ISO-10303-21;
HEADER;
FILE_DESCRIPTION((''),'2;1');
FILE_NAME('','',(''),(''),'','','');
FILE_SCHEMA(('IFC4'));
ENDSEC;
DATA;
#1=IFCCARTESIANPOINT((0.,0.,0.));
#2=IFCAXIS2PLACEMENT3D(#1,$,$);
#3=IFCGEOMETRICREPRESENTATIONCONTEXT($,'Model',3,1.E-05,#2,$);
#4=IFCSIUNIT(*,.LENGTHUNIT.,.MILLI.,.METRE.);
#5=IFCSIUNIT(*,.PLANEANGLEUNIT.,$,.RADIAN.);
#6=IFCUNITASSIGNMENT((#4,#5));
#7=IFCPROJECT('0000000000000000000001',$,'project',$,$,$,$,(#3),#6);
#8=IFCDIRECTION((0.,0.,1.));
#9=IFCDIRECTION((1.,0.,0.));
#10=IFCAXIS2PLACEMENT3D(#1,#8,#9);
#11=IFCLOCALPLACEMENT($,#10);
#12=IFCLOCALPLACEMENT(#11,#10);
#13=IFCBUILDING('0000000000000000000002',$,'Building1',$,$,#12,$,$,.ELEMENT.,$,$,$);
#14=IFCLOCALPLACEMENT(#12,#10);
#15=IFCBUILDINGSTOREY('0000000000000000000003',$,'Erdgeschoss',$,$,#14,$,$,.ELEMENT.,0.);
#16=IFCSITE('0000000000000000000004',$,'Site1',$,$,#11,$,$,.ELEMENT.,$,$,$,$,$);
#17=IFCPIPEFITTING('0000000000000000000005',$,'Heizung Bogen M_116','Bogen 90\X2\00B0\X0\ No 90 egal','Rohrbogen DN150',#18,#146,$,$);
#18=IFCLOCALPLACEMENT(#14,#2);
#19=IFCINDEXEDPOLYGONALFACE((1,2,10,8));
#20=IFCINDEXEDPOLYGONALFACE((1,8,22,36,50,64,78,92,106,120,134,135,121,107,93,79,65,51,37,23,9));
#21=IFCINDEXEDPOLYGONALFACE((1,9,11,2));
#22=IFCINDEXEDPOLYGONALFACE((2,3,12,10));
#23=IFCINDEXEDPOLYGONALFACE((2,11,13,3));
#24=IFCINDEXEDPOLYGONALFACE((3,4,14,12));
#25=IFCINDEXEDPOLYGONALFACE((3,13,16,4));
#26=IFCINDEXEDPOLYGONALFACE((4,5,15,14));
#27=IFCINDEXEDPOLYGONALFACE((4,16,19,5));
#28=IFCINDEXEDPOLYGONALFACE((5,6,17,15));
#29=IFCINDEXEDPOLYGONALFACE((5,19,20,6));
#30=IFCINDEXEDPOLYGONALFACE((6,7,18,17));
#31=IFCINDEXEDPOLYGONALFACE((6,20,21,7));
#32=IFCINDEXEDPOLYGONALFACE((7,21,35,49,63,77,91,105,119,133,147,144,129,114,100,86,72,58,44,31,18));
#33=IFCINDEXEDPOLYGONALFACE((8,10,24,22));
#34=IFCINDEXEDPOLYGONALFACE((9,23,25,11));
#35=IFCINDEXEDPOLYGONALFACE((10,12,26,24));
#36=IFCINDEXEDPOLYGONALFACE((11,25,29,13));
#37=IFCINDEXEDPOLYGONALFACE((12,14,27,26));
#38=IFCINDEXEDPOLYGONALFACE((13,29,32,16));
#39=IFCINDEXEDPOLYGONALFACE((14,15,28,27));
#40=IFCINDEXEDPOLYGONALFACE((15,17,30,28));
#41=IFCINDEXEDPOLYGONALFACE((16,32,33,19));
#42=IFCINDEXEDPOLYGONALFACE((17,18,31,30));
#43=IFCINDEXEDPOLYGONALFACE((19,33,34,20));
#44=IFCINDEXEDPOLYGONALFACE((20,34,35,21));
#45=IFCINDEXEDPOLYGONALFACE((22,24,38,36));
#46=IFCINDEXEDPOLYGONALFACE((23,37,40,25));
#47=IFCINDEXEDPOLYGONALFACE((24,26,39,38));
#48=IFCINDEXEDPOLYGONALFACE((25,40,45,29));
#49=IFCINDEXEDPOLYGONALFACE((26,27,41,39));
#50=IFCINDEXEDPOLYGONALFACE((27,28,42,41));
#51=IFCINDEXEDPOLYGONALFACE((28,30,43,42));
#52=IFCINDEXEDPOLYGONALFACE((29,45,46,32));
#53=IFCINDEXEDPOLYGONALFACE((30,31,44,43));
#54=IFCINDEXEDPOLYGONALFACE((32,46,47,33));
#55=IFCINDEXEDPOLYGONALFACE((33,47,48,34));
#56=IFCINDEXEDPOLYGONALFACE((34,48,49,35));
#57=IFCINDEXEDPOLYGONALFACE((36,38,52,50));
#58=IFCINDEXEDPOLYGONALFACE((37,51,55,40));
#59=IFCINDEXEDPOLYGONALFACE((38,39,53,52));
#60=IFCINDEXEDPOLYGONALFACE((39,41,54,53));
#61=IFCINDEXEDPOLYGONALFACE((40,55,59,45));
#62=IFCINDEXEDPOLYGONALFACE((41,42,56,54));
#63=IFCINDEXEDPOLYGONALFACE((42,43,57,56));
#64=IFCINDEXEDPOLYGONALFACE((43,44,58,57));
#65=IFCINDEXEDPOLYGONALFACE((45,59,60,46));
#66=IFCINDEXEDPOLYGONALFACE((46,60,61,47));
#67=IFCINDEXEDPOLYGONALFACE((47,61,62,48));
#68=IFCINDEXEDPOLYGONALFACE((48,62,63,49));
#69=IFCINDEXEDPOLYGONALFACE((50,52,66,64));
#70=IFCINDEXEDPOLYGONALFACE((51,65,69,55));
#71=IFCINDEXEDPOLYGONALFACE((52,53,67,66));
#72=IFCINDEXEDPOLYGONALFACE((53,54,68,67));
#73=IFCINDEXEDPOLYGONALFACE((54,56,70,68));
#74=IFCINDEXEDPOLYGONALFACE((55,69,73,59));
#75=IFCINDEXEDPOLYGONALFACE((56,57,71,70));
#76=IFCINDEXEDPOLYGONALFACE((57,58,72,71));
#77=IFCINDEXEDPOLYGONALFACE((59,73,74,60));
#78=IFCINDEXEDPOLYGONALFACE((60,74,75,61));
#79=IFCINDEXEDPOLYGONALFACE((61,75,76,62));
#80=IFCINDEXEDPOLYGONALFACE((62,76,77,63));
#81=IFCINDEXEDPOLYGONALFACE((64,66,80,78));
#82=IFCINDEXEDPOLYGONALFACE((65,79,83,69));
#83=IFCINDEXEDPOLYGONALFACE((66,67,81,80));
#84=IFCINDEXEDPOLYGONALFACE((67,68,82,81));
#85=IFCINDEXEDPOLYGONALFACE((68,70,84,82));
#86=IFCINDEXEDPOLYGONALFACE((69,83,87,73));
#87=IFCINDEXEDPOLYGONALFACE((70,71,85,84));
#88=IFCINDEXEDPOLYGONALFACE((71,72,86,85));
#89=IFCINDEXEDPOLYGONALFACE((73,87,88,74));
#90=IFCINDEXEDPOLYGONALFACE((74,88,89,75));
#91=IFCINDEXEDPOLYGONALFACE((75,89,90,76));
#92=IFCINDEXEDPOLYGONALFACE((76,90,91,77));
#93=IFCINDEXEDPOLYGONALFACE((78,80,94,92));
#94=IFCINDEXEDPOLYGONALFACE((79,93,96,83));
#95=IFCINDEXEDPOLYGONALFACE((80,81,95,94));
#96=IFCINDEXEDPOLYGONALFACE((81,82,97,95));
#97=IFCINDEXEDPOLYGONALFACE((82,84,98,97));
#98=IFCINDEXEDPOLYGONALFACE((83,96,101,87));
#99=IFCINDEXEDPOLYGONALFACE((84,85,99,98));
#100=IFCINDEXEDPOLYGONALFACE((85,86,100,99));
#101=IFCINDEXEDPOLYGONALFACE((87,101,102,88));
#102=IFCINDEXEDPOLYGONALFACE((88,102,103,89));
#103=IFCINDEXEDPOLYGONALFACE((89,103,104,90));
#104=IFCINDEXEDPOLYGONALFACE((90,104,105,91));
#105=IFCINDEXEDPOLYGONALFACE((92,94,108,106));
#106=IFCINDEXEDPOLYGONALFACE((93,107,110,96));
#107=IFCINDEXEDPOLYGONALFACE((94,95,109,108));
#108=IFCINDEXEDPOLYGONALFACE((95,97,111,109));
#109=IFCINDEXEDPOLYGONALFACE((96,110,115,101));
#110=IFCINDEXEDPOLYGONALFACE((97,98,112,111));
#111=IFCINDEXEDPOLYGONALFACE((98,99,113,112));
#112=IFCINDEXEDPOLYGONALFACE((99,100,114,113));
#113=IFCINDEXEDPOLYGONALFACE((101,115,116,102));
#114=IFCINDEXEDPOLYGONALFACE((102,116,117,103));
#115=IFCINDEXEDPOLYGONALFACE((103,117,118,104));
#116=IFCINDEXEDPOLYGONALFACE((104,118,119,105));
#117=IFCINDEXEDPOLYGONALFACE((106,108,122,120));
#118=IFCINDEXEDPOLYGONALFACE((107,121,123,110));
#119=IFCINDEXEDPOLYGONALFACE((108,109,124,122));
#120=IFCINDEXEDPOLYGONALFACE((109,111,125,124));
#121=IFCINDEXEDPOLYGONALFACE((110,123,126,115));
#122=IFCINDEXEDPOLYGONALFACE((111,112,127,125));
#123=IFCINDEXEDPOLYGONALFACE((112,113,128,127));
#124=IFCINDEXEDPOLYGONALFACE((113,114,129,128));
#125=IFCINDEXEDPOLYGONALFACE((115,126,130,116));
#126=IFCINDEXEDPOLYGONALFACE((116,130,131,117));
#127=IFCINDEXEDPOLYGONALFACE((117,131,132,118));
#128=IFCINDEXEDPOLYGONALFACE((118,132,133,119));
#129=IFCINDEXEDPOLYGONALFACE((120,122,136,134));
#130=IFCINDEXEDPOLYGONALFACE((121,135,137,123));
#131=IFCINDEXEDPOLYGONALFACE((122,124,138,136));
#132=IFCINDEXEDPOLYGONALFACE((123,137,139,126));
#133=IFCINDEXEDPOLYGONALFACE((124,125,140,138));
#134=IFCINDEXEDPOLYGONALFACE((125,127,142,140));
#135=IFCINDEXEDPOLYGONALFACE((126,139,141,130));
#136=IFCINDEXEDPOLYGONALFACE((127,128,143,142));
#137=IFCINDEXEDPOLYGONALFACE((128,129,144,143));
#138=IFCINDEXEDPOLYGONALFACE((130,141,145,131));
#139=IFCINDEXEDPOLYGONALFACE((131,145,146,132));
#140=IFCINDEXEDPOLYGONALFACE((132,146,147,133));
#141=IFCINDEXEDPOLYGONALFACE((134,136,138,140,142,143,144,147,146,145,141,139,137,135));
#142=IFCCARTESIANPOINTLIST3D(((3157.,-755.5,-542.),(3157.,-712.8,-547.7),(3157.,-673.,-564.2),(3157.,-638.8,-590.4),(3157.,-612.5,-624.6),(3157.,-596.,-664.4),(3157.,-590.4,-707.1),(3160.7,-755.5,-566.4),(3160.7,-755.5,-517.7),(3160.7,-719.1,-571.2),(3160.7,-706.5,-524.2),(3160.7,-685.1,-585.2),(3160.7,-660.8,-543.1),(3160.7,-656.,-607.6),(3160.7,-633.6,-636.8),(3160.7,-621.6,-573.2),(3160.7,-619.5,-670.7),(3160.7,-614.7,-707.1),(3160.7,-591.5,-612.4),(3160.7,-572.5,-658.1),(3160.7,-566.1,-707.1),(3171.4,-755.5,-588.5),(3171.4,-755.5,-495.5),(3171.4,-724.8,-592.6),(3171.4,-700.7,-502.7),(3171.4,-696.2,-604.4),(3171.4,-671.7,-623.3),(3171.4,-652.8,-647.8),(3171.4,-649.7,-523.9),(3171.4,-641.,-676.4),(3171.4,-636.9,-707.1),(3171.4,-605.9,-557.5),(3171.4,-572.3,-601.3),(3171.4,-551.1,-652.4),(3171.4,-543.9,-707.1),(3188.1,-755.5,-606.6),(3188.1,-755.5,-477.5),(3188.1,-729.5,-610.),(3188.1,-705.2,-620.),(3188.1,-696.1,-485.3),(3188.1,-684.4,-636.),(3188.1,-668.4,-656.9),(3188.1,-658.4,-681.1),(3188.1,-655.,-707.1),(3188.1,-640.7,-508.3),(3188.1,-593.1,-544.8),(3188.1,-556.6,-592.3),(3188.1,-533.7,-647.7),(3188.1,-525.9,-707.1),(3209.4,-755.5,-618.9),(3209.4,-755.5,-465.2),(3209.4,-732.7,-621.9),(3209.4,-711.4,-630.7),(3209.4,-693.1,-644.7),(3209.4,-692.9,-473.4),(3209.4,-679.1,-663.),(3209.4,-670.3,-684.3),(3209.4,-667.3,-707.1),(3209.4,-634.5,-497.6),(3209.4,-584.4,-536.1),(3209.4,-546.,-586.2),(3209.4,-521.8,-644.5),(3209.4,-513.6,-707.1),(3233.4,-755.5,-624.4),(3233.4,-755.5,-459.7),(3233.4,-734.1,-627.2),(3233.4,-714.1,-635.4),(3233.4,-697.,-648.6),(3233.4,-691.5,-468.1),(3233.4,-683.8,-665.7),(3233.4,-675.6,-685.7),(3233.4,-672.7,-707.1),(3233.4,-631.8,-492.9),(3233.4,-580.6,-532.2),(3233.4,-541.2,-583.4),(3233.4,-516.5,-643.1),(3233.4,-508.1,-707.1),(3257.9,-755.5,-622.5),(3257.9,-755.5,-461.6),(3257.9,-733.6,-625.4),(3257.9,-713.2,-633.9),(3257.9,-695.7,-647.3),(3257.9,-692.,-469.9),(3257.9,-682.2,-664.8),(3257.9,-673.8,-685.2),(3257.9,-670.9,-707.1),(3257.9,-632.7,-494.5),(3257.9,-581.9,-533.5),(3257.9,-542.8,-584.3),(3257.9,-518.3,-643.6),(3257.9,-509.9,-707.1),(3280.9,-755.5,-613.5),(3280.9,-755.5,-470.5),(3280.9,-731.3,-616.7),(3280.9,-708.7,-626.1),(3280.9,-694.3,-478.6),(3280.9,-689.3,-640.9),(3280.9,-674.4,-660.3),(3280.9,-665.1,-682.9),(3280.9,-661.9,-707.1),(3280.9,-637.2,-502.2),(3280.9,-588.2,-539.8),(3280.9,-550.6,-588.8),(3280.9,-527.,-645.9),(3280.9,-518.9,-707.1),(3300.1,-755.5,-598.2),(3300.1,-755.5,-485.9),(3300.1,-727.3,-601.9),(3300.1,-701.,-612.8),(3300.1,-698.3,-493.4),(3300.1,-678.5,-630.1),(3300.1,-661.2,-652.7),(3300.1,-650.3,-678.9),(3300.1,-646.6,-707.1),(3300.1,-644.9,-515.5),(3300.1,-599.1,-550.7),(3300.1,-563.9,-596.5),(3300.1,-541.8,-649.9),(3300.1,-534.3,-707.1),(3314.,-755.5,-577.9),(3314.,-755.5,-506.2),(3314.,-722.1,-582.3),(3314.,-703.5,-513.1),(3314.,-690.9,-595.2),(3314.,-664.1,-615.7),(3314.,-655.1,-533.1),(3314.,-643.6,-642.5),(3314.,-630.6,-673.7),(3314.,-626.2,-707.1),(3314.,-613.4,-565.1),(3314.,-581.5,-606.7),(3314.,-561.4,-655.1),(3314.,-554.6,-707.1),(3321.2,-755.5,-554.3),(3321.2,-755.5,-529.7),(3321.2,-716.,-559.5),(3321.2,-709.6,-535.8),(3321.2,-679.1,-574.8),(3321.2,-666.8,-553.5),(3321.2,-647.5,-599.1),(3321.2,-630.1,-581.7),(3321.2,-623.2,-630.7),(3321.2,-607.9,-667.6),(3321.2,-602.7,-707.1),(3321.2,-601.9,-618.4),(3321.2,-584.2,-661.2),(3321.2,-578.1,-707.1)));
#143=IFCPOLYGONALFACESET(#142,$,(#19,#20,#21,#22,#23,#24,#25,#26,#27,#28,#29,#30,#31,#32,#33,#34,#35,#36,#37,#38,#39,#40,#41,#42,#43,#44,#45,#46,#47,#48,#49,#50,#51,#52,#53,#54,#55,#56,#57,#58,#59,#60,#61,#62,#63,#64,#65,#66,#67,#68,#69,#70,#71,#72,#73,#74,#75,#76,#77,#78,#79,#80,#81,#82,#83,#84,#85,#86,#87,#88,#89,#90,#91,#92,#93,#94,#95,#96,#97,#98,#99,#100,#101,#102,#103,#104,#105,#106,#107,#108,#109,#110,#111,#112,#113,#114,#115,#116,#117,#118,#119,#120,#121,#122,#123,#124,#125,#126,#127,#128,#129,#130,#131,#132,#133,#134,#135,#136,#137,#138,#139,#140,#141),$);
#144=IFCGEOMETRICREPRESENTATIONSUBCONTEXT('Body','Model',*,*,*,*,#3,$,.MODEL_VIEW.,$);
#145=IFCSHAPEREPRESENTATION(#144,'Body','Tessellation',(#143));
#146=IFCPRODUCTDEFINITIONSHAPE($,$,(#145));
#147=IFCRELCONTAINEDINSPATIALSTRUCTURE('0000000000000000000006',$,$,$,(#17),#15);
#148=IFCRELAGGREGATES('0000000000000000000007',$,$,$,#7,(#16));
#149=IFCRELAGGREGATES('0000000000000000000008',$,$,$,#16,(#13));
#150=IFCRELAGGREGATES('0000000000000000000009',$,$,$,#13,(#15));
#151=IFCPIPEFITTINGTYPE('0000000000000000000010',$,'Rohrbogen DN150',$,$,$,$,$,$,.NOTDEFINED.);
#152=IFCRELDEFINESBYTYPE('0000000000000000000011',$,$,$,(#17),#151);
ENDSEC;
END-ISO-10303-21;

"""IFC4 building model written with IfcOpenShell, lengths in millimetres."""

from ifc_helpers import new_model, entity, si_unit, frame, origin, origin_with_axes, place, context, subcontext, project, spatial, source, transform, mapped, type_object, element, save


model = new_model("IFC4")

# Units and contexts
model_context = context("Model", 3, precision=1e-05, world=origin())
body_context = subcontext(model_context, "Body", "Model", "MODEL_VIEW")
ifc_project = project(units=[si_unit("LENGTHUNIT", "METRE", prefix="MILLI"), si_unit("PLANEANGLEUNIT", "RADIAN")], contexts=[model_context])

# Site, building, storey
site_placement = place(None, origin_with_axes())
site = spatial("IfcSite", under=ifc_project, at=site_placement, Name="Site1", CompositionType="ELEMENT")
building_placement = place(site_placement, origin_with_axes())
building = spatial("IfcBuilding", under=site, at=building_placement, Name="Building1", CompositionType="ELEMENT")
storey_placement = place(building_placement, origin_with_axes())
storey = spatial("IfcBuildingStorey", under=building, at=storey_placement, Name="Erdgeschoss", CompositionType="ELEMENT", Elevation=0.0)

# Pipe fitting
pipe_fitting_type_1 = type_object("IfcPipeFittingType", Name="Rohrbogen DN150", PredefinedType="NOTDEFINED")
shared_shape_1 = source(origin_with_axes(), body_context, "Body", "SolidModel", [
    entity("IfcRevolvedAreaSolid", entity("IfcCircleProfileDef", "AREA", None, entity("IfcAxis2Placement2D", entity("IfcCartesianPoint", [0.0, 0.0]), entity("IfcDirection", [1.0, 0.0])), 82.5), entity("IfcAxis2Placement3D", entity("IfcCartesianPoint", [123.8, 41.3, 0.0]), entity("IfcDirection", [-1.0, 0.0, 0.0]), entity("IfcDirection", [0.0, 0.0, -1.0])), entity("IfcAxis1Placement", entity("IfcCartesianPoint", [0.0, 165.1, 0.0]), entity("IfcDirection", [-1.0, 0.0, 0.0])), 1.570796),
])
pipe_fitting_1_placement = place(storey_placement, frame((3239.6, -631.7, -583.3), z_axis=(0.0, 0.0, 1.0), x_axis=(1.0, 0.0, 0.0)))
element("IfcPipeFitting", 1, at=pipe_fitting_1_placement, inside=storey, type_object=pipe_fitting_type_1, Name="Heizung Bogen M_116", Description="Bogen 90° No 90 egal", ObjectType="Rohrbogen DN150", context=body_context, shape_type="MappedRepresentation", body=[
    mapped(shared_shape_1, transform((0.0, 0.0, 0.0), x_axis=(0.0, 0.0, -1.0), y_axis=(0.0, 1.0, 0.0), z_axis=(1.0, 0.0, 0.0), scale=1.0)),
])

save(model, "model.ifc")
